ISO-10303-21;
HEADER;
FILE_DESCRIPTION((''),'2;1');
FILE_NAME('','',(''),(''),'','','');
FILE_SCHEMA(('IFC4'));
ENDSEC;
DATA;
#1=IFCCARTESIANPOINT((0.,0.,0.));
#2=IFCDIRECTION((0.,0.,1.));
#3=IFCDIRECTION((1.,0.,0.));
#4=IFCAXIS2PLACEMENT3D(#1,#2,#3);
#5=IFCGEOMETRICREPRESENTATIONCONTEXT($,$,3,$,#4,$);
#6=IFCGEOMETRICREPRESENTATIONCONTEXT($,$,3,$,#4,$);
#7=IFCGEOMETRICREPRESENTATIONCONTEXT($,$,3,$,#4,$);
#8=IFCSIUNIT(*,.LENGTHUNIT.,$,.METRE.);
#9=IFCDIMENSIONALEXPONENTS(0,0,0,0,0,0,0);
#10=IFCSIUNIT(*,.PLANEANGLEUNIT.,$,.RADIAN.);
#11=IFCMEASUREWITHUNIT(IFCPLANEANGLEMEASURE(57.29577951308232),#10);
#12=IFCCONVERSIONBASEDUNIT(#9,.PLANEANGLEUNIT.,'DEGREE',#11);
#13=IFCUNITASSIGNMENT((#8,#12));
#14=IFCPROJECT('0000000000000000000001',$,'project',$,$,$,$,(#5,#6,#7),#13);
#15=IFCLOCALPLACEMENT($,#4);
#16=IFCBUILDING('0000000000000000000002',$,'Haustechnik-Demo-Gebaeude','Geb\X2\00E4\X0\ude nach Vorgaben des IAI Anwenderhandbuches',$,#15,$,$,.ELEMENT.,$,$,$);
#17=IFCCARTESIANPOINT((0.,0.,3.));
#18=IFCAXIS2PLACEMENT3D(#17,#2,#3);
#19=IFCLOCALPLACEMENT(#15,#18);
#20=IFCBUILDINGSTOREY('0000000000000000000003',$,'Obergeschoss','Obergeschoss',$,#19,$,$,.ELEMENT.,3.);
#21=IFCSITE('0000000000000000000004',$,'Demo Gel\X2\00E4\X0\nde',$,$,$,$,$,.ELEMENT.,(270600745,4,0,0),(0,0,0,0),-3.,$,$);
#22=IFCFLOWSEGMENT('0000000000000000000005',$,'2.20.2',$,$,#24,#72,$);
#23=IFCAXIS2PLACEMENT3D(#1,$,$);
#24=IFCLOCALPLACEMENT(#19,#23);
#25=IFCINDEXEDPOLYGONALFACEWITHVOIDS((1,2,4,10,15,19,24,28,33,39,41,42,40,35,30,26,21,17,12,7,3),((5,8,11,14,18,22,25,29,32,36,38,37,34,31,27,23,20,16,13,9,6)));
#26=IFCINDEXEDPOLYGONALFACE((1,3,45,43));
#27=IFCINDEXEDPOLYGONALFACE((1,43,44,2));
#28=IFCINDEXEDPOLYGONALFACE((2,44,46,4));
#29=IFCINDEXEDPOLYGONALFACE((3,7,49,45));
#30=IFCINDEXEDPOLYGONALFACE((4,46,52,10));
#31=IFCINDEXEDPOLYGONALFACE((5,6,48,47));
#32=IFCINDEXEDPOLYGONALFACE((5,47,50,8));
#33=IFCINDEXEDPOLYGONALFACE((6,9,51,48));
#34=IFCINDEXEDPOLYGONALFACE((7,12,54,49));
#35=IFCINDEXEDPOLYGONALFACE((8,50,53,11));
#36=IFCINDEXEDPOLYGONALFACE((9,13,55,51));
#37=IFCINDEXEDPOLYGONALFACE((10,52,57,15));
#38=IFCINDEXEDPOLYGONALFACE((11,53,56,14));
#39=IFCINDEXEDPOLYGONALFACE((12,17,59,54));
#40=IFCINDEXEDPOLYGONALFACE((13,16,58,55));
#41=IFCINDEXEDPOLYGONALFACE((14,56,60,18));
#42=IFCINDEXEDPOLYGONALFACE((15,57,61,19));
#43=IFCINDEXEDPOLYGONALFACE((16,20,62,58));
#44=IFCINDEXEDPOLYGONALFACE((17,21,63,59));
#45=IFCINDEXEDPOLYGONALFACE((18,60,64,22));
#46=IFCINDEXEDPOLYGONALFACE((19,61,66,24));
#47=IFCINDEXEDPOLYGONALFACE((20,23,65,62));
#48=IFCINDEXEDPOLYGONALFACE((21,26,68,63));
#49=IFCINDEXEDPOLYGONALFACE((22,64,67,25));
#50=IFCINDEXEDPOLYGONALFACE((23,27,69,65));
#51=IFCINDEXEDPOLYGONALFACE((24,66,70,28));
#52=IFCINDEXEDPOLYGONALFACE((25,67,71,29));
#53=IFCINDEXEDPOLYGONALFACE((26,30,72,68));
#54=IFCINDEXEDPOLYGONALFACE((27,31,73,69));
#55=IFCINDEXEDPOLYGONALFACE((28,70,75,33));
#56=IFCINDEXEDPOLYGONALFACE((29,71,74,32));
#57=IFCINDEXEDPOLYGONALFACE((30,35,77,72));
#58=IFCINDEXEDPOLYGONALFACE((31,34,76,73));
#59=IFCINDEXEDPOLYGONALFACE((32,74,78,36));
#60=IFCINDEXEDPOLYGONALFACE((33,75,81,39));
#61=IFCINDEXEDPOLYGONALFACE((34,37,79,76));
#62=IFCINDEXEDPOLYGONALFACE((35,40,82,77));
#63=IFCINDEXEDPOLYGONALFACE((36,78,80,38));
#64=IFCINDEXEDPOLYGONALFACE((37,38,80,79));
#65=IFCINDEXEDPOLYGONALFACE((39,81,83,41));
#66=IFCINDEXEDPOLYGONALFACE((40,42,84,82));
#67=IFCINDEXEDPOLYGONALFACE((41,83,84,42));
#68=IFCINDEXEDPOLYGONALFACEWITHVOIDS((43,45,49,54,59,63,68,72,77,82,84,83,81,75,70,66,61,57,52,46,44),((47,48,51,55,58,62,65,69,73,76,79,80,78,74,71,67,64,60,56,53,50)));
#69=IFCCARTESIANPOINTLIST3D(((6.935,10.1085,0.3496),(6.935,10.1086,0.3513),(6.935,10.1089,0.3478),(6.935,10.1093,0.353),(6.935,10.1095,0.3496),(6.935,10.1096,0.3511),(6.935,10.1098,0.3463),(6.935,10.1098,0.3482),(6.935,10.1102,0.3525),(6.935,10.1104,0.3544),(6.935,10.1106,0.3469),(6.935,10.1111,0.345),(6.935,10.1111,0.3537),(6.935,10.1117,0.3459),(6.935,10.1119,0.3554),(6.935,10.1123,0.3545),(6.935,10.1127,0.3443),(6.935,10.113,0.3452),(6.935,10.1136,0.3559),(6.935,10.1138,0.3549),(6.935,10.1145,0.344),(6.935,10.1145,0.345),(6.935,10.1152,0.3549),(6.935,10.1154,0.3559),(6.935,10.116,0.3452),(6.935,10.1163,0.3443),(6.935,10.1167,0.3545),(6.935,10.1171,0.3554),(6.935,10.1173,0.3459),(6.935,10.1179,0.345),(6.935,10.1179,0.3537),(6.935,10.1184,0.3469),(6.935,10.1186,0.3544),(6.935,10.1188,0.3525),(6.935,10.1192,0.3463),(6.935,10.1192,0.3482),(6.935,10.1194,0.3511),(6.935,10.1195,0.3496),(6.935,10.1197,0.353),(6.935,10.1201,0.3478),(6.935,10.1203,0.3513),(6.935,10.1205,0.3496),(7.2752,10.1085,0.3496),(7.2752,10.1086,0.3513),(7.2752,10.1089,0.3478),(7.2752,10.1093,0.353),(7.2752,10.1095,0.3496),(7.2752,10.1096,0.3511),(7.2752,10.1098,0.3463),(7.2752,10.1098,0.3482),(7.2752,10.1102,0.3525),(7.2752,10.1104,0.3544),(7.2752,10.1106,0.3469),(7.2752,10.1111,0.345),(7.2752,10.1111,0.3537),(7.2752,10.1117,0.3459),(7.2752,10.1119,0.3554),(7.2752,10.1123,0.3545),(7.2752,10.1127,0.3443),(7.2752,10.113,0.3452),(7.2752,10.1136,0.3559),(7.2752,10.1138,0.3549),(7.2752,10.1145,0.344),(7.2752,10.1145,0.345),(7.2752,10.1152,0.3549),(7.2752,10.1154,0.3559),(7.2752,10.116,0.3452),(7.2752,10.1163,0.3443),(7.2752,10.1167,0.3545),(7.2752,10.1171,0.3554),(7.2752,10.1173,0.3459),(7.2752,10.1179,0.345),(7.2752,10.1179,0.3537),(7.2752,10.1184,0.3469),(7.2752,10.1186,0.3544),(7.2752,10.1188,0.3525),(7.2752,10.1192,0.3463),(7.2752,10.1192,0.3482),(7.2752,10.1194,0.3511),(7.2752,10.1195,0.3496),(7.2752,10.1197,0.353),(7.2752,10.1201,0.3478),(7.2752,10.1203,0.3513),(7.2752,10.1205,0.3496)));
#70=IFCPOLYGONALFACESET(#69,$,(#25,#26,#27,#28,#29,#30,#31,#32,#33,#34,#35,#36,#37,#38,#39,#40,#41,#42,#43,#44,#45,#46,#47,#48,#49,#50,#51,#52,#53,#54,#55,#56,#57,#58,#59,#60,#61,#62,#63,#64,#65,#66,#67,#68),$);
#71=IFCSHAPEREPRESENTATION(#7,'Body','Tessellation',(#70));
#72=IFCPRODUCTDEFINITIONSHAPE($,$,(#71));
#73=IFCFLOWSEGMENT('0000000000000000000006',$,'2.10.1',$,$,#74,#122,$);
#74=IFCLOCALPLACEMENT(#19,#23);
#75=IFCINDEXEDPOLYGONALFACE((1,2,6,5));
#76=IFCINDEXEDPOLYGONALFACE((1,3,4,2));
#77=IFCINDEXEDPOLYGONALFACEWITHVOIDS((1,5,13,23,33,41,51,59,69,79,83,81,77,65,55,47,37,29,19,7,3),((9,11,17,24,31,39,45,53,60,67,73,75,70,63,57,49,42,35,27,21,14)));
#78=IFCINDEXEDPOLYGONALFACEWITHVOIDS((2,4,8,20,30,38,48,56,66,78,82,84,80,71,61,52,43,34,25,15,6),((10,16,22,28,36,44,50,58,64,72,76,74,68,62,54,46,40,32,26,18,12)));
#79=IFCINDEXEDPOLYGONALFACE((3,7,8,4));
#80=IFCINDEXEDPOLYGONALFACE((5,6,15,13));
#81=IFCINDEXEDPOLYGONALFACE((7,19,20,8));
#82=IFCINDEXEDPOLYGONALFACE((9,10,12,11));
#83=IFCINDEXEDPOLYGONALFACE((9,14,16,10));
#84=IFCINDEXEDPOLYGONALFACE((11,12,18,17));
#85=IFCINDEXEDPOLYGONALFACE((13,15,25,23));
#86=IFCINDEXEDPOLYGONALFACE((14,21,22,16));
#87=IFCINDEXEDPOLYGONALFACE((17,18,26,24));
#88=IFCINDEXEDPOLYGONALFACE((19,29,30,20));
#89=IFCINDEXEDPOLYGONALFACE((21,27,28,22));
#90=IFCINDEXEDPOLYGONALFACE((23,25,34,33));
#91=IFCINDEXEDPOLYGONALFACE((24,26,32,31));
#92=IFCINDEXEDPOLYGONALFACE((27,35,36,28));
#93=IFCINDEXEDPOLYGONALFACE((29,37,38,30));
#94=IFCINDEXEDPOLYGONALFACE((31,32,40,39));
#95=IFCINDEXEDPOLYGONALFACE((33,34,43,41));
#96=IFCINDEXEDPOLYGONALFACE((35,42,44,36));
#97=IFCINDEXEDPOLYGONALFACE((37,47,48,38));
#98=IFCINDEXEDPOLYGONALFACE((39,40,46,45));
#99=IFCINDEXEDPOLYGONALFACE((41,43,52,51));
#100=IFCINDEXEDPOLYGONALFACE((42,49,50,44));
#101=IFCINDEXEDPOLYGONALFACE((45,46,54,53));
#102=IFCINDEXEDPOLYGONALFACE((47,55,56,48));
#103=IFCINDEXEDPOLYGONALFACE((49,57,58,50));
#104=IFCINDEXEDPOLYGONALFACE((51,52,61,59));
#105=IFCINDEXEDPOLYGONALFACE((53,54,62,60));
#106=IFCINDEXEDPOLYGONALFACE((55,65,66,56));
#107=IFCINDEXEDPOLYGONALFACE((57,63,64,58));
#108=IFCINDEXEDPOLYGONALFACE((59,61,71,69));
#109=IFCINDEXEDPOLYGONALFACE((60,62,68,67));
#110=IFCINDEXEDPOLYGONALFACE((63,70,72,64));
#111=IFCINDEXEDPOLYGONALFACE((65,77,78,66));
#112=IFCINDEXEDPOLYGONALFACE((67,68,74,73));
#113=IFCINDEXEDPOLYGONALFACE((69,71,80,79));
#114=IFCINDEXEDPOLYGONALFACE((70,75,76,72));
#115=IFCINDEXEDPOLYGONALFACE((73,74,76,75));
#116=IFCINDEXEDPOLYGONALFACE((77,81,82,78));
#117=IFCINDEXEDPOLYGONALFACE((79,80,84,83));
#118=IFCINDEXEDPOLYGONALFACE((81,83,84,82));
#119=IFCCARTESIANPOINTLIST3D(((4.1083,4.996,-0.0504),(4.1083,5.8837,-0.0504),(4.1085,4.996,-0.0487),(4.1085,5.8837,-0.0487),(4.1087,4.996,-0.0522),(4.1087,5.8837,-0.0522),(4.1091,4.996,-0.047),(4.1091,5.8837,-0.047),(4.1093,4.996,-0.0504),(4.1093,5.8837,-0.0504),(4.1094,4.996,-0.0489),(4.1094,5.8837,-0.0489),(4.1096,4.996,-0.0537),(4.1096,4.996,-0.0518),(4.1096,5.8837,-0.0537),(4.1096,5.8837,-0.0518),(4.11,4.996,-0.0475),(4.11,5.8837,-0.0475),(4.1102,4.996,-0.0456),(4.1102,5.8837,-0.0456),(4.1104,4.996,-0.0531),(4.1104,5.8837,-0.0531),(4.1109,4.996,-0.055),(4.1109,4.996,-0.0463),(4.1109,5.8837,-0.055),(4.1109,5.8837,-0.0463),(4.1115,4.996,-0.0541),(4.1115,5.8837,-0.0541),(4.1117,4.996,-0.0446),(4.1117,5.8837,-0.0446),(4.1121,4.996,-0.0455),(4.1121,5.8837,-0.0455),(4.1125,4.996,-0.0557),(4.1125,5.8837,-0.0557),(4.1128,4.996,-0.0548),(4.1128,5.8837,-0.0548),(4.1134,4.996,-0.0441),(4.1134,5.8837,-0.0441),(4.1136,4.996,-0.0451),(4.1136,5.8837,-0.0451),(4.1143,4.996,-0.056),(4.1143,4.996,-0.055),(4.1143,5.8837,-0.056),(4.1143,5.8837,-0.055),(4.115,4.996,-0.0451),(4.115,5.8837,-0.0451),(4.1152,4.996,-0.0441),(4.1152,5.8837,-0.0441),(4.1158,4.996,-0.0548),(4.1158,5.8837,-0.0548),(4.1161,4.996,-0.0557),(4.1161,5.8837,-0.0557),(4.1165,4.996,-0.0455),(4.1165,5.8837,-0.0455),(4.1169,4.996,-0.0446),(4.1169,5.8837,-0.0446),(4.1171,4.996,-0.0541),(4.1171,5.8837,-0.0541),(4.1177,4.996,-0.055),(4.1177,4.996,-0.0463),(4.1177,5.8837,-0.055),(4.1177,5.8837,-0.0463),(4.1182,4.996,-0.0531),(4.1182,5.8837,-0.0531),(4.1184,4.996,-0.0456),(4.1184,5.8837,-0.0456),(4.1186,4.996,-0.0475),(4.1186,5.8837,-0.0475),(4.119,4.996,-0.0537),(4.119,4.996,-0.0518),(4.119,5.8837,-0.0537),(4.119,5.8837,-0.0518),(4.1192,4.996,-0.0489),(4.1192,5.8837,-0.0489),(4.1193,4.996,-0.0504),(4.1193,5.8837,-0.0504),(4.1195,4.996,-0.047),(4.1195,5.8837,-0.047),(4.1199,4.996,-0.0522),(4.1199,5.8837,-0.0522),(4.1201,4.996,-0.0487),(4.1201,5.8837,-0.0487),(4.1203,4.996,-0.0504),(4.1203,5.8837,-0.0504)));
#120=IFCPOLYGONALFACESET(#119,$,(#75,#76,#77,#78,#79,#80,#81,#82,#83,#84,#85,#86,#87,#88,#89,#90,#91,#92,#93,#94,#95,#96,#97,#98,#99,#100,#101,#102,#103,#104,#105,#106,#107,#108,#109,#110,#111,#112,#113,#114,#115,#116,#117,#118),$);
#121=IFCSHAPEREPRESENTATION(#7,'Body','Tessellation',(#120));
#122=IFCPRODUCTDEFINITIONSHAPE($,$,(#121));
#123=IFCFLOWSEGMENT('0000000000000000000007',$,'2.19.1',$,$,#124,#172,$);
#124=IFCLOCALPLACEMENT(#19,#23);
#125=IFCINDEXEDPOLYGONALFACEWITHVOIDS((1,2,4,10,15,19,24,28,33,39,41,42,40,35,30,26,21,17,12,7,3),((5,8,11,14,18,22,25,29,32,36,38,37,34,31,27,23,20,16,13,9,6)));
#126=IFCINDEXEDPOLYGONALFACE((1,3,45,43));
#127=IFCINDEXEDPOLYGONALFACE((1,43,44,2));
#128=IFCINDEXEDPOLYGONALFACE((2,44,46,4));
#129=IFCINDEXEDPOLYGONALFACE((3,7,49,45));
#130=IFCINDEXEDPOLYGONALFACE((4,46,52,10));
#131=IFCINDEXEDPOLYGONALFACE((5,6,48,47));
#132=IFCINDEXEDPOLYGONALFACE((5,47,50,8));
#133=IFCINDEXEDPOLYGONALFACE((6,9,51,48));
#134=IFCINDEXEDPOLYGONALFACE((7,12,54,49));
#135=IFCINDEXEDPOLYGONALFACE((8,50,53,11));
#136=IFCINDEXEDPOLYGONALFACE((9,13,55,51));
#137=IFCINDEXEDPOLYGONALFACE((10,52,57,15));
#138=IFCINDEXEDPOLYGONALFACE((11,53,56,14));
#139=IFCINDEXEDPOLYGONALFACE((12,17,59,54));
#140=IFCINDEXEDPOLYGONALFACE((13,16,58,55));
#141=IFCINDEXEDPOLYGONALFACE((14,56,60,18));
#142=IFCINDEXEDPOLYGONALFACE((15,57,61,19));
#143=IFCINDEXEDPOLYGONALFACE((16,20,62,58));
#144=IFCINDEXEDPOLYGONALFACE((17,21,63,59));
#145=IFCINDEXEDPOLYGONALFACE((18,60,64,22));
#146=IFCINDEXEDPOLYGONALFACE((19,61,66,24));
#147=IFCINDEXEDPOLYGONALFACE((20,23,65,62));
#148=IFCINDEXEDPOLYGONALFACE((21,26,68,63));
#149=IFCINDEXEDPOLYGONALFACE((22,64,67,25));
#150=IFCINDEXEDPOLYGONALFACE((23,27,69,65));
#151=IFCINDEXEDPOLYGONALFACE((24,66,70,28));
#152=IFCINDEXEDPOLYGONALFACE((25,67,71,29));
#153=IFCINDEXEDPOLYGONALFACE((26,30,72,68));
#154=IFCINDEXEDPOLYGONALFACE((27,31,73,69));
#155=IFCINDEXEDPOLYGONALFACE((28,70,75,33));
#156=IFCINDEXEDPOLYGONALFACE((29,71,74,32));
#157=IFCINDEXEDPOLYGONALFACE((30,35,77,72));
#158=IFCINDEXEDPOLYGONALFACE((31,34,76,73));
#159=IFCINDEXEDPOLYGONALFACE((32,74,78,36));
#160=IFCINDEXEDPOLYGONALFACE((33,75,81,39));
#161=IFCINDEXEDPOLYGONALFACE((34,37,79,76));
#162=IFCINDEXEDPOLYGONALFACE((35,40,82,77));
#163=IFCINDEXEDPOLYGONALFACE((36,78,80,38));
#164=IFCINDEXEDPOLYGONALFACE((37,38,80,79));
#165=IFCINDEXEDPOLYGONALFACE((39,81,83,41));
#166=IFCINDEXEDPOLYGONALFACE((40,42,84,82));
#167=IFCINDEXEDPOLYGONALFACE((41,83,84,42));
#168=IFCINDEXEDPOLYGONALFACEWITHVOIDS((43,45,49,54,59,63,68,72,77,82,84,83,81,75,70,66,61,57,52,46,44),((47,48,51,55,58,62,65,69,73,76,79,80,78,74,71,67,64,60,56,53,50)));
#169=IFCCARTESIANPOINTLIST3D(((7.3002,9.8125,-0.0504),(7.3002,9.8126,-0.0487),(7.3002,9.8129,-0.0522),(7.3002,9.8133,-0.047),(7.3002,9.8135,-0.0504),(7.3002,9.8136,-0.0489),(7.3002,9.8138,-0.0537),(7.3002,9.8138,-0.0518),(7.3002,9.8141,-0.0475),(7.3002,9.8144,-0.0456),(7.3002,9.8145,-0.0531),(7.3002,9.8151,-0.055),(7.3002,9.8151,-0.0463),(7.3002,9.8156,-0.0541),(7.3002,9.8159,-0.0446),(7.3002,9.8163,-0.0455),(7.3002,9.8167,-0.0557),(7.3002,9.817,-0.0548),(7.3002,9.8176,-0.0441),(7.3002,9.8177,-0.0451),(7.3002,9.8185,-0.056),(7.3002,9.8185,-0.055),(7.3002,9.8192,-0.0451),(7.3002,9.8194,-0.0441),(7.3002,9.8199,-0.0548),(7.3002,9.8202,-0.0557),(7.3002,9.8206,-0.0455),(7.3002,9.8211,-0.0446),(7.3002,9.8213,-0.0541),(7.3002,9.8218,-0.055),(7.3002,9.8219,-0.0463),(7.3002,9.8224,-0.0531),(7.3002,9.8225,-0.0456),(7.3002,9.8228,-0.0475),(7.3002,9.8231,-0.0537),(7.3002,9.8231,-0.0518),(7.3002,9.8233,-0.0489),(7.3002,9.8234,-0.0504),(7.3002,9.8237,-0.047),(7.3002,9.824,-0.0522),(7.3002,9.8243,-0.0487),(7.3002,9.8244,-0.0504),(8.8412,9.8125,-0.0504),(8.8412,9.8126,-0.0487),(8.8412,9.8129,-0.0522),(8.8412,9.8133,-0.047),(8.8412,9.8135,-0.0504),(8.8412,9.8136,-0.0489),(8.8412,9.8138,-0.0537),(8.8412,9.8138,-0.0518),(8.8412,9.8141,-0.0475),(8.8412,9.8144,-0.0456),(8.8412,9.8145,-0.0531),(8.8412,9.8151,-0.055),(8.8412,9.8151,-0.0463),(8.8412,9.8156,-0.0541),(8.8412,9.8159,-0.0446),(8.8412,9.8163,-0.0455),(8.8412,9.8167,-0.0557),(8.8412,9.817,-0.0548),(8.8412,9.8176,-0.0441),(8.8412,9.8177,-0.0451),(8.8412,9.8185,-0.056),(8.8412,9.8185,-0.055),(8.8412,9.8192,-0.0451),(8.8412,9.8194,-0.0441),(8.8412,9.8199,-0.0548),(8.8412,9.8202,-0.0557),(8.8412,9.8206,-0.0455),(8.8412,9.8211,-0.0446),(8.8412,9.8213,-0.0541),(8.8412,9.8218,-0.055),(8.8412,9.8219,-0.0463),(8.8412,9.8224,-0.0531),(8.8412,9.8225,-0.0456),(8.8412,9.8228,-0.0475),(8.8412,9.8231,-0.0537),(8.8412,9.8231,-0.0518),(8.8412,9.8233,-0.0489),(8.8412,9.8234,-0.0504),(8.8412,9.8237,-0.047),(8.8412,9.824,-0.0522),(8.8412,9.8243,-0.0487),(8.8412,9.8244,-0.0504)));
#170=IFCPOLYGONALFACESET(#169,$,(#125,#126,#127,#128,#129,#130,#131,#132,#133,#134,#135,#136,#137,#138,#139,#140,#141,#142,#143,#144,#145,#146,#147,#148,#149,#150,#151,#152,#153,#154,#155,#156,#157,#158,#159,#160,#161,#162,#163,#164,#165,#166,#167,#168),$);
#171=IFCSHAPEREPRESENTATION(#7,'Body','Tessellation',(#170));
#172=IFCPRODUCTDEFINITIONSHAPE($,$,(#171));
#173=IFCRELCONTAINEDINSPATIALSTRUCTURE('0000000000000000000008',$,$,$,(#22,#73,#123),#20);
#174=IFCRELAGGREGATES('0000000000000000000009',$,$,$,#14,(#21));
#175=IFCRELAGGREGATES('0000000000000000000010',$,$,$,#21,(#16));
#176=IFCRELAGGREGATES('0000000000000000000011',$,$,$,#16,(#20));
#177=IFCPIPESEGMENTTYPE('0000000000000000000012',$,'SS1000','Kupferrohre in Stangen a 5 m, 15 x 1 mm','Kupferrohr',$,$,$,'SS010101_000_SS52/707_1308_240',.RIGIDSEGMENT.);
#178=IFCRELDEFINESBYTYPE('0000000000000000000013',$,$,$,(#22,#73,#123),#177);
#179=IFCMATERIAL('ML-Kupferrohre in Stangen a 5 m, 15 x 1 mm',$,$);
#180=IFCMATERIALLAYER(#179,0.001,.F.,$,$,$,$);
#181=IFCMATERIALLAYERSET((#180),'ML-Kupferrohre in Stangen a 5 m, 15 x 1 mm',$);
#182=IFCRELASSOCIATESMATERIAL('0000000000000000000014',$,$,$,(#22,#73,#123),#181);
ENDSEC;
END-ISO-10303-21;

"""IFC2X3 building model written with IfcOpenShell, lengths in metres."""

from ifc_helpers import new_model, entity, si_unit, converted_unit, frame, origin_with_axes, origin_2d_with_axis, place, context, project, spatial, hollow_circle, extrude, material, layer, layer_set, layer_usage, type_object, element, save


model = new_model("IFC2X3")

# Units and contexts
context_of_model_1 = context(None, 3, world=origin_with_axes())
context_of_model_2 = context(None, 3, world=origin_with_axes())
context_of_model_3 = context(None, 3, world=origin_with_axes())
ifc_project = project(units=[si_unit("LENGTHUNIT", "METRE"), converted_unit("PLANEANGLEUNIT", "DEGREE", entity("IfcPlaneAngleMeasure", 57.29577951308232), si_unit("PLANEANGLEUNIT", "RADIAN"), dimensions=[0, 0, 0, 0, 0, 0, 0])], contexts=[context_of_model_1, context_of_model_2, context_of_model_3])

# Site, building, storey
site = spatial("IfcSite", under=ifc_project, Name="Demo Gelände", CompositionType="ELEMENT", RefLatitude=(270600745, 4, 0, 0), RefLongitude=(0, 0, 0, 0), RefElevation=-3.0)
building_placement = place(None, origin_with_axes())
building = spatial("IfcBuilding", under=site, at=building_placement, Name="Haustechnik-Demo-Gebaeude", Description="Gebäude nach Vorgaben des IAI Anwenderhandbuches", CompositionType="ELEMENT")
storey_placement = place(building_placement, frame((0.0, 0.0, 3.0), z_axis=(0.0, 0.0, 1.0), x_axis=(1.0, 0.0, 0.0)))
storey = spatial("IfcBuildingStorey", under=building, at=storey_placement, Name="Obergeschoss", Description="Obergeschoss", CompositionType="ELEMENT", Elevation=3.0)

# Flow segments
ifc_material_1 = material(Name="ML-Kupferrohre in Stangen a 5 m, 15 x 1 mm")
ifc_layer_1 = layer(ifc_material_1, 0.001, ventilated=False)
ifc_layer_set_1 = layer_set([ifc_layer_1], Name="ML-Kupferrohre in Stangen a 5 m, 15 x 1 mm")
ifc_layer_usage_1 = layer_usage(ifc_layer_set_1, "AXIS2", "POSITIVE", 0.0)
pipe_segment_type_1 = type_object("IfcPipeSegmentType", Name="SS1000", Description="Kupferrohre in Stangen a 5 m, 15 x 1 mm", ApplicableOccurrence="Kupferrohr", ElementType="SS010101_000_SS52/707_1308_240", PredefinedType="RIGIDSEGMENT")
flow_segment_1_placement = place(storey_placement, frame((7.2752, 10.1145, 0.35), z_axis=(-1.0, -0.000001, 0.0), x_axis=(0.0, 0.0, -1.0)))
element("IfcFlowSegment", 1, at=flow_segment_1_placement, inside=storey, type_object=pipe_segment_type_1, material=ifc_layer_usage_1, Name="2.20.2", context=context_of_model_3, shape_type="SweptSolid", body=[
    extrude(hollow_circle(Radius=0.006, WallThickness=0.001, at=origin_2d_with_axis()), origin_with_axes(), (0.0, 0.0, 1.0), 0.3402),
])
flow_segment_2_placement = place(storey_placement, frame((4.1143, 5.8837, -0.05), z_axis=(0.0, -1.0, 0.0), x_axis=(0.0, 0.0, -1.0)))
element("IfcFlowSegment", 2, at=flow_segment_2_placement, inside=storey, type_object=pipe_segment_type_1, material=ifc_layer_usage_1, Name="2.10.1", context=context_of_model_3, shape_type="SweptSolid", body=[
    extrude(hollow_circle(Radius=0.006, WallThickness=0.001, at=origin_2d_with_axis()), origin_with_axes(), (0.0, 0.0, 1.0), 0.8877),
])
flow_segment_3_placement = place(storey_placement, frame((7.3002, 9.8185, -0.05), z_axis=(1.0, 0.0, 0.0), x_axis=(0.0, 0.0, -1.0)))
element("IfcFlowSegment", 3, at=flow_segment_3_placement, inside=storey, type_object=pipe_segment_type_1, material=ifc_layer_usage_1, Name="2.19.1", context=context_of_model_3, shape_type="SweptSolid", body=[
    extrude(hollow_circle(Radius=0.006, WallThickness=0.001, at=origin_2d_with_axis()), origin_with_axes(), (0.0, 0.0, 1.0), 1.541),
])

save(model, "model.ifc")
